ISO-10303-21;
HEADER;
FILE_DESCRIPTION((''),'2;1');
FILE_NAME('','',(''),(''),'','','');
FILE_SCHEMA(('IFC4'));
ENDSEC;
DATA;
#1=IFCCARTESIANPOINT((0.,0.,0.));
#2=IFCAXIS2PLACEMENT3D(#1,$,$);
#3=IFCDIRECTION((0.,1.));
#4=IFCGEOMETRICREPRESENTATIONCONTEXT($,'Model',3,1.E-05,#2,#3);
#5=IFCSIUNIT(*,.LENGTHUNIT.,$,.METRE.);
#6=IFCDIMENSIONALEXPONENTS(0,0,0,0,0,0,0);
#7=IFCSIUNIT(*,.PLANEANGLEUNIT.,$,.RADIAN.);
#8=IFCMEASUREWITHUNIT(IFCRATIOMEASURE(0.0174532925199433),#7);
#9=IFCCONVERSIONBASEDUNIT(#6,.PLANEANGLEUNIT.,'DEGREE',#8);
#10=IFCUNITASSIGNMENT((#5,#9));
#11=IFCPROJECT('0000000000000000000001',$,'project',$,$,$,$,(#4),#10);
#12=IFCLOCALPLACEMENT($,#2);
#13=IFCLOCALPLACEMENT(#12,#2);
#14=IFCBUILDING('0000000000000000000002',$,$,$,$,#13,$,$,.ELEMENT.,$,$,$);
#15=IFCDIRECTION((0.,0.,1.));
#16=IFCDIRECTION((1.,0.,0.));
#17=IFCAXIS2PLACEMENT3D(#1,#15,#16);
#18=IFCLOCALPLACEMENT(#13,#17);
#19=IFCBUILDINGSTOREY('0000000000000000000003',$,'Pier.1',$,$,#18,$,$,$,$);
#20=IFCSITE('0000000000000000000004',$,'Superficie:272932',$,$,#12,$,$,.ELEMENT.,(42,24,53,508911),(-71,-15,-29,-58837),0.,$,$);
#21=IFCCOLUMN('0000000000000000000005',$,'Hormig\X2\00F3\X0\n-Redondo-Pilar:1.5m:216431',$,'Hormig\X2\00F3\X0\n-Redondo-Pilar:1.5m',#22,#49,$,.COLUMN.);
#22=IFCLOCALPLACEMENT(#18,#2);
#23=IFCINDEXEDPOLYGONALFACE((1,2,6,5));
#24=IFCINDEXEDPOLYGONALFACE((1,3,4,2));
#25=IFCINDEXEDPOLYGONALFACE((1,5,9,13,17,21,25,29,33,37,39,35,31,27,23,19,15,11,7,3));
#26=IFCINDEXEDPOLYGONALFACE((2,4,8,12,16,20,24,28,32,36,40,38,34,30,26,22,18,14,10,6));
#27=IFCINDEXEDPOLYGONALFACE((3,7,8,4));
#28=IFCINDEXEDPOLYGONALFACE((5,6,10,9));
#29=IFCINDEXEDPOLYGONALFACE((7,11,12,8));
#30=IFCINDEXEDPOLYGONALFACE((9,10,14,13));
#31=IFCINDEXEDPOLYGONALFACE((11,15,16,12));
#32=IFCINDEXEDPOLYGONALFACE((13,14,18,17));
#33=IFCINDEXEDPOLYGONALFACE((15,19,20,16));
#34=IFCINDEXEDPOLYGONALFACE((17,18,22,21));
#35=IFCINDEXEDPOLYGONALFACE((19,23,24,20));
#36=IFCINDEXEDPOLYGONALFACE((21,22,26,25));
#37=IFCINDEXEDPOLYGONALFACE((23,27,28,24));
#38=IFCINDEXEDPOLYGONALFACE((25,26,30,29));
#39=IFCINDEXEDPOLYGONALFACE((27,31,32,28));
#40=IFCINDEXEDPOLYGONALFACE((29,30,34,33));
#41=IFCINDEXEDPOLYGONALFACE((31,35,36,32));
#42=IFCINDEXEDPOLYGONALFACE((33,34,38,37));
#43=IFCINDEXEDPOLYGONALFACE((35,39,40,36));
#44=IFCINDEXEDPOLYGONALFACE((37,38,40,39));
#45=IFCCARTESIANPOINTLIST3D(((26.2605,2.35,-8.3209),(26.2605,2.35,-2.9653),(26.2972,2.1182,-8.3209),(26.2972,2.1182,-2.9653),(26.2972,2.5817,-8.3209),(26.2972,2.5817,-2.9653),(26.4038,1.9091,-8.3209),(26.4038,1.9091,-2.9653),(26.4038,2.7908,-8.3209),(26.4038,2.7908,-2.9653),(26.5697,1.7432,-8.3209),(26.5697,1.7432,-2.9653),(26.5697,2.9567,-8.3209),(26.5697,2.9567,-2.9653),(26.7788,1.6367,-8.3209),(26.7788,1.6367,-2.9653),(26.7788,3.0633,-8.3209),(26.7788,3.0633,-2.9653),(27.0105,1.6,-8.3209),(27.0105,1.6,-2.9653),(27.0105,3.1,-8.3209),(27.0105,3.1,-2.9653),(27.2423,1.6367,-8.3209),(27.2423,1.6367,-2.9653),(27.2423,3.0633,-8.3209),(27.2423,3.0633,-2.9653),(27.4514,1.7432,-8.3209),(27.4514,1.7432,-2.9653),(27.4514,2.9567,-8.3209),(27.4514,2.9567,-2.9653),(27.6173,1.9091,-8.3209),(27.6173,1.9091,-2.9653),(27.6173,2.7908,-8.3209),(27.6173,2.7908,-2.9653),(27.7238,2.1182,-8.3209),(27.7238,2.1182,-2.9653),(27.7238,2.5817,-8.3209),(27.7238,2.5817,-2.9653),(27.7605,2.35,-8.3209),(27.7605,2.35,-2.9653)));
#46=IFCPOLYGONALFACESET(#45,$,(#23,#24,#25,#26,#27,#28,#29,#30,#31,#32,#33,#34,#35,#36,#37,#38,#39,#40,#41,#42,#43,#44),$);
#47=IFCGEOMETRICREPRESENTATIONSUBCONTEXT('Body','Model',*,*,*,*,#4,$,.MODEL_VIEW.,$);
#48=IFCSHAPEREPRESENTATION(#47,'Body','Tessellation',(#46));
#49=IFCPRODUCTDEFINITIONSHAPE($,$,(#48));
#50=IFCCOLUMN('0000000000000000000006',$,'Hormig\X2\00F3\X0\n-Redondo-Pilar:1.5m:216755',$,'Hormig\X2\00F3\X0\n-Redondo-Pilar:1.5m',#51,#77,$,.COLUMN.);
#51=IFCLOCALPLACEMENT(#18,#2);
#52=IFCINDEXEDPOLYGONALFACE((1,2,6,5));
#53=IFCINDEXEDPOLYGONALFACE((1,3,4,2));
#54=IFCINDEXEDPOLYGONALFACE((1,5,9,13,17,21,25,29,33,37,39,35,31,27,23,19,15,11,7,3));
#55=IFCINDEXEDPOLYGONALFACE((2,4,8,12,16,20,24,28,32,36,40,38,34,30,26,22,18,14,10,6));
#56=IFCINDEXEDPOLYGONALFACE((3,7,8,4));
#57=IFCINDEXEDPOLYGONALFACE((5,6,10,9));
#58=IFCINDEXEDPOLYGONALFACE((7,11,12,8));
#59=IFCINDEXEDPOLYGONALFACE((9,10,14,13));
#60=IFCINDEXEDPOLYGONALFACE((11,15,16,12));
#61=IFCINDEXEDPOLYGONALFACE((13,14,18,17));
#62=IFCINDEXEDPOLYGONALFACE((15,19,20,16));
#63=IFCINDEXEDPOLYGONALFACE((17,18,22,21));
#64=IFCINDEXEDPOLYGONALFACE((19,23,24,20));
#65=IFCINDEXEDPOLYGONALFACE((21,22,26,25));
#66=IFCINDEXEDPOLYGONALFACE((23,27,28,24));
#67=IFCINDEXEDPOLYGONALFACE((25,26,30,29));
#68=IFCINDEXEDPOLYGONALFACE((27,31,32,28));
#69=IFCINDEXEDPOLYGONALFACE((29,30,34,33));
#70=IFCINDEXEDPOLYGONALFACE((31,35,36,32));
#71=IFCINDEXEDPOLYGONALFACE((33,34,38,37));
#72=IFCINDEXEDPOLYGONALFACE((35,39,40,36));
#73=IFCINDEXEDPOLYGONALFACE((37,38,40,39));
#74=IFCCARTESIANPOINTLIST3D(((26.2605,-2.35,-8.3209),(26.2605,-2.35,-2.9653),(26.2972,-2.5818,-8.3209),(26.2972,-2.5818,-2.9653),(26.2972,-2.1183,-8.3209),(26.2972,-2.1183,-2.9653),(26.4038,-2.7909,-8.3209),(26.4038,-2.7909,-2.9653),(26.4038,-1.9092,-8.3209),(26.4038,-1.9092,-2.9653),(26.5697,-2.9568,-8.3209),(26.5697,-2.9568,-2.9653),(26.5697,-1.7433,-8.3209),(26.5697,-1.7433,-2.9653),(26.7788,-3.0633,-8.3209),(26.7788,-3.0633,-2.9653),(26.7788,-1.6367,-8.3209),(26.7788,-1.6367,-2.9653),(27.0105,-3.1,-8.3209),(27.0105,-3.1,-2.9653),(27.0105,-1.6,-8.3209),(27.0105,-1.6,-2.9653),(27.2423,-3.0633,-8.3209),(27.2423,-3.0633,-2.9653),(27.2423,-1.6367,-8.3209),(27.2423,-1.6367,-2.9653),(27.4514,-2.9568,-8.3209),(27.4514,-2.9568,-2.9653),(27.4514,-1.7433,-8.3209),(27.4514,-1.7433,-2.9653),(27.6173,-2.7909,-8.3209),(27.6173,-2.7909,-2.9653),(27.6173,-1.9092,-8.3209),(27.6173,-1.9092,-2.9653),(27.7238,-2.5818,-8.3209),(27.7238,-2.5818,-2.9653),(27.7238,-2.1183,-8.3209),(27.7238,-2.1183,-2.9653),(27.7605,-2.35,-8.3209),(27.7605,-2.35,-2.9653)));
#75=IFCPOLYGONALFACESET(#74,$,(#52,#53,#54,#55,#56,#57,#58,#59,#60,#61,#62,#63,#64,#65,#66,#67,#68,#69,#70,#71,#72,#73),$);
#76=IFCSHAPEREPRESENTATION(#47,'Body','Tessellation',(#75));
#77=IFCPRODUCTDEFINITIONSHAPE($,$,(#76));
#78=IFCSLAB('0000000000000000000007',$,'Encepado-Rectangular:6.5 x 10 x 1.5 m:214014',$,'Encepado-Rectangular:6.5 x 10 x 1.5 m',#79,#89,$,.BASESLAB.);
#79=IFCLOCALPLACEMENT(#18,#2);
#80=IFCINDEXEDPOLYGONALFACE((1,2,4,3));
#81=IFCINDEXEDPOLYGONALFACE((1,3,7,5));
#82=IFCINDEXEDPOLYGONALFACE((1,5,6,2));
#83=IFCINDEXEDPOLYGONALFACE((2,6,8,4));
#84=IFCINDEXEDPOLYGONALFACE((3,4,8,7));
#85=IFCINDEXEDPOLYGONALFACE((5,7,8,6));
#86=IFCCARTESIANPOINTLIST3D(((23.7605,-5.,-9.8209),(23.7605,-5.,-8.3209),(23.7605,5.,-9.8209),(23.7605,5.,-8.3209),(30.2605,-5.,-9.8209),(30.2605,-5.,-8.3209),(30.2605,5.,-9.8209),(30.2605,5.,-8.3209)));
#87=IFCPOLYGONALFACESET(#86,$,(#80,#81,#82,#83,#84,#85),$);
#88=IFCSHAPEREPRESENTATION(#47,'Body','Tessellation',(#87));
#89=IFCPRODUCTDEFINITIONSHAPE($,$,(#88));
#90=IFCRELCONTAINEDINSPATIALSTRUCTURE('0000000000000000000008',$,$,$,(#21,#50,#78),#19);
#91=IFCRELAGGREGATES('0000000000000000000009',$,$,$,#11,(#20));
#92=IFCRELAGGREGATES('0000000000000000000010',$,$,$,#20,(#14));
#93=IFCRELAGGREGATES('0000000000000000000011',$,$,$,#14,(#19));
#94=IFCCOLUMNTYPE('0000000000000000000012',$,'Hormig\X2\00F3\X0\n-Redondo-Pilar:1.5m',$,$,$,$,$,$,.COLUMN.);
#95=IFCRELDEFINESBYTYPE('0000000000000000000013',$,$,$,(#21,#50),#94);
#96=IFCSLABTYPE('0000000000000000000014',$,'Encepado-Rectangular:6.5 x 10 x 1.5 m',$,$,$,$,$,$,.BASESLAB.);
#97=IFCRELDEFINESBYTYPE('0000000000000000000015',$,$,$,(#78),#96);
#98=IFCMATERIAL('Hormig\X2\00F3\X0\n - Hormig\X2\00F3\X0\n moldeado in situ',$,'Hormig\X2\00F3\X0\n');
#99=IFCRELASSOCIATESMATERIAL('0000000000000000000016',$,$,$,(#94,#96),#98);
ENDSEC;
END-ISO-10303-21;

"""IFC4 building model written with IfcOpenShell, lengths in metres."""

from ifc_helpers import new_model, entity, si_unit, converted_unit, direction, frame, origin, origin_with_axes, place, context, subcontext, project, spatial, indexed_curve, outline, extrude, source, transform, mapped, material, type_object, type_shapes, element, save


model = new_model("IFC4")

# Units and contexts
model_context = context("Model", 3, precision=1e-05, world=origin(), true_north=direction((0.0, 1.0)))
body_context = subcontext(model_context, "Body", "Model", "MODEL_VIEW")
ifc_project = project(units=[si_unit("LENGTHUNIT", "METRE"), converted_unit("PLANEANGLEUNIT", "DEGREE", entity("IfcRatioMeasure", 0.0174532925199433), si_unit("PLANEANGLEUNIT", "RADIAN"), dimensions=[0, 0, 0, 0, 0, 0, 0])], contexts=[model_context])

# Site, building, storey
site_placement = place(None, origin())
site = spatial("IfcSite", under=ifc_project, at=site_placement, Name="Superficie:272932", CompositionType="ELEMENT", RefLatitude=(42, 24, 53, 508911), RefLongitude=(-71, -15, -29, -58837), RefElevation=0.0)
building_placement = place(site_placement, origin())
building = spatial("IfcBuilding", under=site, at=building_placement, CompositionType="ELEMENT")
storey_placement = place(building_placement, origin_with_axes())
storey = spatial("IfcBuildingStorey", under=building, at=storey_placement, Name="Pier.1")

# Columns
ifc_material = material(Name="Hormigón - Hormigón moldeado in situ", Category="Hormigón")
column_type = type_object("IfcColumnType", Name="Hormigón-Redondo-Pilar:1.5m", PredefinedType="COLUMN", material=ifc_material)
shared_shape = source(origin(), body_context, "Body", "SweptSolid", [
    extrude(outline(indexed_curve([(0.75, 0.0), (0.7133, 0.2318), (0.6068, 0.4408), (0.4408, 0.6068), (0.2318, 0.7133), (0.0, 0.75), (-0.2318, 0.7133), (-0.4408, 0.6068), (-0.6068, 0.4408), (-0.7133, 0.2318), (-0.75, 0.0), (-0.7133, -0.2318), (-0.6068, -0.4408), (-0.4408, -0.6068), (-0.2318, -0.7133), (0.0, -0.75), (0.2318, -0.7133), (0.4408, -0.6068), (0.6068, -0.4408), (0.7133, -0.2318), (0.75, 0.0)], self_intersect=False)), frame((0.0, 0.0, -8.3209)), (0.0, 0.0, 1.0), 5.3556),
])
type_shapes(column_type, [shared_shape])
for number, where, z_axis, x_axis, name in (
    (1, (27.0105, 2.35, 0.0), (0.0, 0.0, 1.0), (1.0, 0.0, 0.0), "Hormigón-Redondo-Pilar:1.5m:216431"),
    (2, (27.0105, -2.35, 0.0), (0.0, 0.0, 1.0), (1.0, 0.0, 0.0), "Hormigón-Redondo-Pilar:1.5m:216755"),
):
    element("IfcColumn", number, at=place(storey_placement, frame(where, z_axis=z_axis, x_axis=x_axis)), inside=storey, type_object=column_type, Name=name, ObjectType="Hormigón-Redondo-Pilar:1.5m", PredefinedType="COLUMN", context=body_context, shape_type="MappedRepresentation", body=[
        mapped(shared_shape, transform((0.0, 0.0, 0.0), scale=1.0)),
    ])

# Slab
slab_type = type_object("IfcSlabType", Name="Encepado-Rectangular:6.5 x 10 x 1.5 m", PredefinedType="BASESLAB", material=ifc_material)
slab_placement = place(storey_placement, frame((0.0, 0.0, -8.3209), z_axis=(0.0, 0.0, 1.0), x_axis=(1.0, 0.0, 0.0)))
element("IfcSlab", 3, at=slab_placement, inside=storey, type_object=slab_type, Name="Encepado-Rectangular:6.5 x 10 x 1.5 m:214014", ObjectType="Encepado-Rectangular:6.5 x 10 x 1.5 m", PredefinedType="BASESLAB", context=body_context, shape_type="SweptSolid", body=[
    extrude(outline(indexed_curve([(-3.25, -5.0), (3.25, -5.0), (3.25, 5.0), (-3.25, 5.0), (-3.25, -5.0)], self_intersect=False)), frame((27.0105, 0.0, -1.5), z_axis=(0.0, 0.0, 1.0), x_axis=(-1.0, 0.0, 0.0)), (0.0, 0.0, 1.0), 1.5),
])

save(model, "model.ifc")
